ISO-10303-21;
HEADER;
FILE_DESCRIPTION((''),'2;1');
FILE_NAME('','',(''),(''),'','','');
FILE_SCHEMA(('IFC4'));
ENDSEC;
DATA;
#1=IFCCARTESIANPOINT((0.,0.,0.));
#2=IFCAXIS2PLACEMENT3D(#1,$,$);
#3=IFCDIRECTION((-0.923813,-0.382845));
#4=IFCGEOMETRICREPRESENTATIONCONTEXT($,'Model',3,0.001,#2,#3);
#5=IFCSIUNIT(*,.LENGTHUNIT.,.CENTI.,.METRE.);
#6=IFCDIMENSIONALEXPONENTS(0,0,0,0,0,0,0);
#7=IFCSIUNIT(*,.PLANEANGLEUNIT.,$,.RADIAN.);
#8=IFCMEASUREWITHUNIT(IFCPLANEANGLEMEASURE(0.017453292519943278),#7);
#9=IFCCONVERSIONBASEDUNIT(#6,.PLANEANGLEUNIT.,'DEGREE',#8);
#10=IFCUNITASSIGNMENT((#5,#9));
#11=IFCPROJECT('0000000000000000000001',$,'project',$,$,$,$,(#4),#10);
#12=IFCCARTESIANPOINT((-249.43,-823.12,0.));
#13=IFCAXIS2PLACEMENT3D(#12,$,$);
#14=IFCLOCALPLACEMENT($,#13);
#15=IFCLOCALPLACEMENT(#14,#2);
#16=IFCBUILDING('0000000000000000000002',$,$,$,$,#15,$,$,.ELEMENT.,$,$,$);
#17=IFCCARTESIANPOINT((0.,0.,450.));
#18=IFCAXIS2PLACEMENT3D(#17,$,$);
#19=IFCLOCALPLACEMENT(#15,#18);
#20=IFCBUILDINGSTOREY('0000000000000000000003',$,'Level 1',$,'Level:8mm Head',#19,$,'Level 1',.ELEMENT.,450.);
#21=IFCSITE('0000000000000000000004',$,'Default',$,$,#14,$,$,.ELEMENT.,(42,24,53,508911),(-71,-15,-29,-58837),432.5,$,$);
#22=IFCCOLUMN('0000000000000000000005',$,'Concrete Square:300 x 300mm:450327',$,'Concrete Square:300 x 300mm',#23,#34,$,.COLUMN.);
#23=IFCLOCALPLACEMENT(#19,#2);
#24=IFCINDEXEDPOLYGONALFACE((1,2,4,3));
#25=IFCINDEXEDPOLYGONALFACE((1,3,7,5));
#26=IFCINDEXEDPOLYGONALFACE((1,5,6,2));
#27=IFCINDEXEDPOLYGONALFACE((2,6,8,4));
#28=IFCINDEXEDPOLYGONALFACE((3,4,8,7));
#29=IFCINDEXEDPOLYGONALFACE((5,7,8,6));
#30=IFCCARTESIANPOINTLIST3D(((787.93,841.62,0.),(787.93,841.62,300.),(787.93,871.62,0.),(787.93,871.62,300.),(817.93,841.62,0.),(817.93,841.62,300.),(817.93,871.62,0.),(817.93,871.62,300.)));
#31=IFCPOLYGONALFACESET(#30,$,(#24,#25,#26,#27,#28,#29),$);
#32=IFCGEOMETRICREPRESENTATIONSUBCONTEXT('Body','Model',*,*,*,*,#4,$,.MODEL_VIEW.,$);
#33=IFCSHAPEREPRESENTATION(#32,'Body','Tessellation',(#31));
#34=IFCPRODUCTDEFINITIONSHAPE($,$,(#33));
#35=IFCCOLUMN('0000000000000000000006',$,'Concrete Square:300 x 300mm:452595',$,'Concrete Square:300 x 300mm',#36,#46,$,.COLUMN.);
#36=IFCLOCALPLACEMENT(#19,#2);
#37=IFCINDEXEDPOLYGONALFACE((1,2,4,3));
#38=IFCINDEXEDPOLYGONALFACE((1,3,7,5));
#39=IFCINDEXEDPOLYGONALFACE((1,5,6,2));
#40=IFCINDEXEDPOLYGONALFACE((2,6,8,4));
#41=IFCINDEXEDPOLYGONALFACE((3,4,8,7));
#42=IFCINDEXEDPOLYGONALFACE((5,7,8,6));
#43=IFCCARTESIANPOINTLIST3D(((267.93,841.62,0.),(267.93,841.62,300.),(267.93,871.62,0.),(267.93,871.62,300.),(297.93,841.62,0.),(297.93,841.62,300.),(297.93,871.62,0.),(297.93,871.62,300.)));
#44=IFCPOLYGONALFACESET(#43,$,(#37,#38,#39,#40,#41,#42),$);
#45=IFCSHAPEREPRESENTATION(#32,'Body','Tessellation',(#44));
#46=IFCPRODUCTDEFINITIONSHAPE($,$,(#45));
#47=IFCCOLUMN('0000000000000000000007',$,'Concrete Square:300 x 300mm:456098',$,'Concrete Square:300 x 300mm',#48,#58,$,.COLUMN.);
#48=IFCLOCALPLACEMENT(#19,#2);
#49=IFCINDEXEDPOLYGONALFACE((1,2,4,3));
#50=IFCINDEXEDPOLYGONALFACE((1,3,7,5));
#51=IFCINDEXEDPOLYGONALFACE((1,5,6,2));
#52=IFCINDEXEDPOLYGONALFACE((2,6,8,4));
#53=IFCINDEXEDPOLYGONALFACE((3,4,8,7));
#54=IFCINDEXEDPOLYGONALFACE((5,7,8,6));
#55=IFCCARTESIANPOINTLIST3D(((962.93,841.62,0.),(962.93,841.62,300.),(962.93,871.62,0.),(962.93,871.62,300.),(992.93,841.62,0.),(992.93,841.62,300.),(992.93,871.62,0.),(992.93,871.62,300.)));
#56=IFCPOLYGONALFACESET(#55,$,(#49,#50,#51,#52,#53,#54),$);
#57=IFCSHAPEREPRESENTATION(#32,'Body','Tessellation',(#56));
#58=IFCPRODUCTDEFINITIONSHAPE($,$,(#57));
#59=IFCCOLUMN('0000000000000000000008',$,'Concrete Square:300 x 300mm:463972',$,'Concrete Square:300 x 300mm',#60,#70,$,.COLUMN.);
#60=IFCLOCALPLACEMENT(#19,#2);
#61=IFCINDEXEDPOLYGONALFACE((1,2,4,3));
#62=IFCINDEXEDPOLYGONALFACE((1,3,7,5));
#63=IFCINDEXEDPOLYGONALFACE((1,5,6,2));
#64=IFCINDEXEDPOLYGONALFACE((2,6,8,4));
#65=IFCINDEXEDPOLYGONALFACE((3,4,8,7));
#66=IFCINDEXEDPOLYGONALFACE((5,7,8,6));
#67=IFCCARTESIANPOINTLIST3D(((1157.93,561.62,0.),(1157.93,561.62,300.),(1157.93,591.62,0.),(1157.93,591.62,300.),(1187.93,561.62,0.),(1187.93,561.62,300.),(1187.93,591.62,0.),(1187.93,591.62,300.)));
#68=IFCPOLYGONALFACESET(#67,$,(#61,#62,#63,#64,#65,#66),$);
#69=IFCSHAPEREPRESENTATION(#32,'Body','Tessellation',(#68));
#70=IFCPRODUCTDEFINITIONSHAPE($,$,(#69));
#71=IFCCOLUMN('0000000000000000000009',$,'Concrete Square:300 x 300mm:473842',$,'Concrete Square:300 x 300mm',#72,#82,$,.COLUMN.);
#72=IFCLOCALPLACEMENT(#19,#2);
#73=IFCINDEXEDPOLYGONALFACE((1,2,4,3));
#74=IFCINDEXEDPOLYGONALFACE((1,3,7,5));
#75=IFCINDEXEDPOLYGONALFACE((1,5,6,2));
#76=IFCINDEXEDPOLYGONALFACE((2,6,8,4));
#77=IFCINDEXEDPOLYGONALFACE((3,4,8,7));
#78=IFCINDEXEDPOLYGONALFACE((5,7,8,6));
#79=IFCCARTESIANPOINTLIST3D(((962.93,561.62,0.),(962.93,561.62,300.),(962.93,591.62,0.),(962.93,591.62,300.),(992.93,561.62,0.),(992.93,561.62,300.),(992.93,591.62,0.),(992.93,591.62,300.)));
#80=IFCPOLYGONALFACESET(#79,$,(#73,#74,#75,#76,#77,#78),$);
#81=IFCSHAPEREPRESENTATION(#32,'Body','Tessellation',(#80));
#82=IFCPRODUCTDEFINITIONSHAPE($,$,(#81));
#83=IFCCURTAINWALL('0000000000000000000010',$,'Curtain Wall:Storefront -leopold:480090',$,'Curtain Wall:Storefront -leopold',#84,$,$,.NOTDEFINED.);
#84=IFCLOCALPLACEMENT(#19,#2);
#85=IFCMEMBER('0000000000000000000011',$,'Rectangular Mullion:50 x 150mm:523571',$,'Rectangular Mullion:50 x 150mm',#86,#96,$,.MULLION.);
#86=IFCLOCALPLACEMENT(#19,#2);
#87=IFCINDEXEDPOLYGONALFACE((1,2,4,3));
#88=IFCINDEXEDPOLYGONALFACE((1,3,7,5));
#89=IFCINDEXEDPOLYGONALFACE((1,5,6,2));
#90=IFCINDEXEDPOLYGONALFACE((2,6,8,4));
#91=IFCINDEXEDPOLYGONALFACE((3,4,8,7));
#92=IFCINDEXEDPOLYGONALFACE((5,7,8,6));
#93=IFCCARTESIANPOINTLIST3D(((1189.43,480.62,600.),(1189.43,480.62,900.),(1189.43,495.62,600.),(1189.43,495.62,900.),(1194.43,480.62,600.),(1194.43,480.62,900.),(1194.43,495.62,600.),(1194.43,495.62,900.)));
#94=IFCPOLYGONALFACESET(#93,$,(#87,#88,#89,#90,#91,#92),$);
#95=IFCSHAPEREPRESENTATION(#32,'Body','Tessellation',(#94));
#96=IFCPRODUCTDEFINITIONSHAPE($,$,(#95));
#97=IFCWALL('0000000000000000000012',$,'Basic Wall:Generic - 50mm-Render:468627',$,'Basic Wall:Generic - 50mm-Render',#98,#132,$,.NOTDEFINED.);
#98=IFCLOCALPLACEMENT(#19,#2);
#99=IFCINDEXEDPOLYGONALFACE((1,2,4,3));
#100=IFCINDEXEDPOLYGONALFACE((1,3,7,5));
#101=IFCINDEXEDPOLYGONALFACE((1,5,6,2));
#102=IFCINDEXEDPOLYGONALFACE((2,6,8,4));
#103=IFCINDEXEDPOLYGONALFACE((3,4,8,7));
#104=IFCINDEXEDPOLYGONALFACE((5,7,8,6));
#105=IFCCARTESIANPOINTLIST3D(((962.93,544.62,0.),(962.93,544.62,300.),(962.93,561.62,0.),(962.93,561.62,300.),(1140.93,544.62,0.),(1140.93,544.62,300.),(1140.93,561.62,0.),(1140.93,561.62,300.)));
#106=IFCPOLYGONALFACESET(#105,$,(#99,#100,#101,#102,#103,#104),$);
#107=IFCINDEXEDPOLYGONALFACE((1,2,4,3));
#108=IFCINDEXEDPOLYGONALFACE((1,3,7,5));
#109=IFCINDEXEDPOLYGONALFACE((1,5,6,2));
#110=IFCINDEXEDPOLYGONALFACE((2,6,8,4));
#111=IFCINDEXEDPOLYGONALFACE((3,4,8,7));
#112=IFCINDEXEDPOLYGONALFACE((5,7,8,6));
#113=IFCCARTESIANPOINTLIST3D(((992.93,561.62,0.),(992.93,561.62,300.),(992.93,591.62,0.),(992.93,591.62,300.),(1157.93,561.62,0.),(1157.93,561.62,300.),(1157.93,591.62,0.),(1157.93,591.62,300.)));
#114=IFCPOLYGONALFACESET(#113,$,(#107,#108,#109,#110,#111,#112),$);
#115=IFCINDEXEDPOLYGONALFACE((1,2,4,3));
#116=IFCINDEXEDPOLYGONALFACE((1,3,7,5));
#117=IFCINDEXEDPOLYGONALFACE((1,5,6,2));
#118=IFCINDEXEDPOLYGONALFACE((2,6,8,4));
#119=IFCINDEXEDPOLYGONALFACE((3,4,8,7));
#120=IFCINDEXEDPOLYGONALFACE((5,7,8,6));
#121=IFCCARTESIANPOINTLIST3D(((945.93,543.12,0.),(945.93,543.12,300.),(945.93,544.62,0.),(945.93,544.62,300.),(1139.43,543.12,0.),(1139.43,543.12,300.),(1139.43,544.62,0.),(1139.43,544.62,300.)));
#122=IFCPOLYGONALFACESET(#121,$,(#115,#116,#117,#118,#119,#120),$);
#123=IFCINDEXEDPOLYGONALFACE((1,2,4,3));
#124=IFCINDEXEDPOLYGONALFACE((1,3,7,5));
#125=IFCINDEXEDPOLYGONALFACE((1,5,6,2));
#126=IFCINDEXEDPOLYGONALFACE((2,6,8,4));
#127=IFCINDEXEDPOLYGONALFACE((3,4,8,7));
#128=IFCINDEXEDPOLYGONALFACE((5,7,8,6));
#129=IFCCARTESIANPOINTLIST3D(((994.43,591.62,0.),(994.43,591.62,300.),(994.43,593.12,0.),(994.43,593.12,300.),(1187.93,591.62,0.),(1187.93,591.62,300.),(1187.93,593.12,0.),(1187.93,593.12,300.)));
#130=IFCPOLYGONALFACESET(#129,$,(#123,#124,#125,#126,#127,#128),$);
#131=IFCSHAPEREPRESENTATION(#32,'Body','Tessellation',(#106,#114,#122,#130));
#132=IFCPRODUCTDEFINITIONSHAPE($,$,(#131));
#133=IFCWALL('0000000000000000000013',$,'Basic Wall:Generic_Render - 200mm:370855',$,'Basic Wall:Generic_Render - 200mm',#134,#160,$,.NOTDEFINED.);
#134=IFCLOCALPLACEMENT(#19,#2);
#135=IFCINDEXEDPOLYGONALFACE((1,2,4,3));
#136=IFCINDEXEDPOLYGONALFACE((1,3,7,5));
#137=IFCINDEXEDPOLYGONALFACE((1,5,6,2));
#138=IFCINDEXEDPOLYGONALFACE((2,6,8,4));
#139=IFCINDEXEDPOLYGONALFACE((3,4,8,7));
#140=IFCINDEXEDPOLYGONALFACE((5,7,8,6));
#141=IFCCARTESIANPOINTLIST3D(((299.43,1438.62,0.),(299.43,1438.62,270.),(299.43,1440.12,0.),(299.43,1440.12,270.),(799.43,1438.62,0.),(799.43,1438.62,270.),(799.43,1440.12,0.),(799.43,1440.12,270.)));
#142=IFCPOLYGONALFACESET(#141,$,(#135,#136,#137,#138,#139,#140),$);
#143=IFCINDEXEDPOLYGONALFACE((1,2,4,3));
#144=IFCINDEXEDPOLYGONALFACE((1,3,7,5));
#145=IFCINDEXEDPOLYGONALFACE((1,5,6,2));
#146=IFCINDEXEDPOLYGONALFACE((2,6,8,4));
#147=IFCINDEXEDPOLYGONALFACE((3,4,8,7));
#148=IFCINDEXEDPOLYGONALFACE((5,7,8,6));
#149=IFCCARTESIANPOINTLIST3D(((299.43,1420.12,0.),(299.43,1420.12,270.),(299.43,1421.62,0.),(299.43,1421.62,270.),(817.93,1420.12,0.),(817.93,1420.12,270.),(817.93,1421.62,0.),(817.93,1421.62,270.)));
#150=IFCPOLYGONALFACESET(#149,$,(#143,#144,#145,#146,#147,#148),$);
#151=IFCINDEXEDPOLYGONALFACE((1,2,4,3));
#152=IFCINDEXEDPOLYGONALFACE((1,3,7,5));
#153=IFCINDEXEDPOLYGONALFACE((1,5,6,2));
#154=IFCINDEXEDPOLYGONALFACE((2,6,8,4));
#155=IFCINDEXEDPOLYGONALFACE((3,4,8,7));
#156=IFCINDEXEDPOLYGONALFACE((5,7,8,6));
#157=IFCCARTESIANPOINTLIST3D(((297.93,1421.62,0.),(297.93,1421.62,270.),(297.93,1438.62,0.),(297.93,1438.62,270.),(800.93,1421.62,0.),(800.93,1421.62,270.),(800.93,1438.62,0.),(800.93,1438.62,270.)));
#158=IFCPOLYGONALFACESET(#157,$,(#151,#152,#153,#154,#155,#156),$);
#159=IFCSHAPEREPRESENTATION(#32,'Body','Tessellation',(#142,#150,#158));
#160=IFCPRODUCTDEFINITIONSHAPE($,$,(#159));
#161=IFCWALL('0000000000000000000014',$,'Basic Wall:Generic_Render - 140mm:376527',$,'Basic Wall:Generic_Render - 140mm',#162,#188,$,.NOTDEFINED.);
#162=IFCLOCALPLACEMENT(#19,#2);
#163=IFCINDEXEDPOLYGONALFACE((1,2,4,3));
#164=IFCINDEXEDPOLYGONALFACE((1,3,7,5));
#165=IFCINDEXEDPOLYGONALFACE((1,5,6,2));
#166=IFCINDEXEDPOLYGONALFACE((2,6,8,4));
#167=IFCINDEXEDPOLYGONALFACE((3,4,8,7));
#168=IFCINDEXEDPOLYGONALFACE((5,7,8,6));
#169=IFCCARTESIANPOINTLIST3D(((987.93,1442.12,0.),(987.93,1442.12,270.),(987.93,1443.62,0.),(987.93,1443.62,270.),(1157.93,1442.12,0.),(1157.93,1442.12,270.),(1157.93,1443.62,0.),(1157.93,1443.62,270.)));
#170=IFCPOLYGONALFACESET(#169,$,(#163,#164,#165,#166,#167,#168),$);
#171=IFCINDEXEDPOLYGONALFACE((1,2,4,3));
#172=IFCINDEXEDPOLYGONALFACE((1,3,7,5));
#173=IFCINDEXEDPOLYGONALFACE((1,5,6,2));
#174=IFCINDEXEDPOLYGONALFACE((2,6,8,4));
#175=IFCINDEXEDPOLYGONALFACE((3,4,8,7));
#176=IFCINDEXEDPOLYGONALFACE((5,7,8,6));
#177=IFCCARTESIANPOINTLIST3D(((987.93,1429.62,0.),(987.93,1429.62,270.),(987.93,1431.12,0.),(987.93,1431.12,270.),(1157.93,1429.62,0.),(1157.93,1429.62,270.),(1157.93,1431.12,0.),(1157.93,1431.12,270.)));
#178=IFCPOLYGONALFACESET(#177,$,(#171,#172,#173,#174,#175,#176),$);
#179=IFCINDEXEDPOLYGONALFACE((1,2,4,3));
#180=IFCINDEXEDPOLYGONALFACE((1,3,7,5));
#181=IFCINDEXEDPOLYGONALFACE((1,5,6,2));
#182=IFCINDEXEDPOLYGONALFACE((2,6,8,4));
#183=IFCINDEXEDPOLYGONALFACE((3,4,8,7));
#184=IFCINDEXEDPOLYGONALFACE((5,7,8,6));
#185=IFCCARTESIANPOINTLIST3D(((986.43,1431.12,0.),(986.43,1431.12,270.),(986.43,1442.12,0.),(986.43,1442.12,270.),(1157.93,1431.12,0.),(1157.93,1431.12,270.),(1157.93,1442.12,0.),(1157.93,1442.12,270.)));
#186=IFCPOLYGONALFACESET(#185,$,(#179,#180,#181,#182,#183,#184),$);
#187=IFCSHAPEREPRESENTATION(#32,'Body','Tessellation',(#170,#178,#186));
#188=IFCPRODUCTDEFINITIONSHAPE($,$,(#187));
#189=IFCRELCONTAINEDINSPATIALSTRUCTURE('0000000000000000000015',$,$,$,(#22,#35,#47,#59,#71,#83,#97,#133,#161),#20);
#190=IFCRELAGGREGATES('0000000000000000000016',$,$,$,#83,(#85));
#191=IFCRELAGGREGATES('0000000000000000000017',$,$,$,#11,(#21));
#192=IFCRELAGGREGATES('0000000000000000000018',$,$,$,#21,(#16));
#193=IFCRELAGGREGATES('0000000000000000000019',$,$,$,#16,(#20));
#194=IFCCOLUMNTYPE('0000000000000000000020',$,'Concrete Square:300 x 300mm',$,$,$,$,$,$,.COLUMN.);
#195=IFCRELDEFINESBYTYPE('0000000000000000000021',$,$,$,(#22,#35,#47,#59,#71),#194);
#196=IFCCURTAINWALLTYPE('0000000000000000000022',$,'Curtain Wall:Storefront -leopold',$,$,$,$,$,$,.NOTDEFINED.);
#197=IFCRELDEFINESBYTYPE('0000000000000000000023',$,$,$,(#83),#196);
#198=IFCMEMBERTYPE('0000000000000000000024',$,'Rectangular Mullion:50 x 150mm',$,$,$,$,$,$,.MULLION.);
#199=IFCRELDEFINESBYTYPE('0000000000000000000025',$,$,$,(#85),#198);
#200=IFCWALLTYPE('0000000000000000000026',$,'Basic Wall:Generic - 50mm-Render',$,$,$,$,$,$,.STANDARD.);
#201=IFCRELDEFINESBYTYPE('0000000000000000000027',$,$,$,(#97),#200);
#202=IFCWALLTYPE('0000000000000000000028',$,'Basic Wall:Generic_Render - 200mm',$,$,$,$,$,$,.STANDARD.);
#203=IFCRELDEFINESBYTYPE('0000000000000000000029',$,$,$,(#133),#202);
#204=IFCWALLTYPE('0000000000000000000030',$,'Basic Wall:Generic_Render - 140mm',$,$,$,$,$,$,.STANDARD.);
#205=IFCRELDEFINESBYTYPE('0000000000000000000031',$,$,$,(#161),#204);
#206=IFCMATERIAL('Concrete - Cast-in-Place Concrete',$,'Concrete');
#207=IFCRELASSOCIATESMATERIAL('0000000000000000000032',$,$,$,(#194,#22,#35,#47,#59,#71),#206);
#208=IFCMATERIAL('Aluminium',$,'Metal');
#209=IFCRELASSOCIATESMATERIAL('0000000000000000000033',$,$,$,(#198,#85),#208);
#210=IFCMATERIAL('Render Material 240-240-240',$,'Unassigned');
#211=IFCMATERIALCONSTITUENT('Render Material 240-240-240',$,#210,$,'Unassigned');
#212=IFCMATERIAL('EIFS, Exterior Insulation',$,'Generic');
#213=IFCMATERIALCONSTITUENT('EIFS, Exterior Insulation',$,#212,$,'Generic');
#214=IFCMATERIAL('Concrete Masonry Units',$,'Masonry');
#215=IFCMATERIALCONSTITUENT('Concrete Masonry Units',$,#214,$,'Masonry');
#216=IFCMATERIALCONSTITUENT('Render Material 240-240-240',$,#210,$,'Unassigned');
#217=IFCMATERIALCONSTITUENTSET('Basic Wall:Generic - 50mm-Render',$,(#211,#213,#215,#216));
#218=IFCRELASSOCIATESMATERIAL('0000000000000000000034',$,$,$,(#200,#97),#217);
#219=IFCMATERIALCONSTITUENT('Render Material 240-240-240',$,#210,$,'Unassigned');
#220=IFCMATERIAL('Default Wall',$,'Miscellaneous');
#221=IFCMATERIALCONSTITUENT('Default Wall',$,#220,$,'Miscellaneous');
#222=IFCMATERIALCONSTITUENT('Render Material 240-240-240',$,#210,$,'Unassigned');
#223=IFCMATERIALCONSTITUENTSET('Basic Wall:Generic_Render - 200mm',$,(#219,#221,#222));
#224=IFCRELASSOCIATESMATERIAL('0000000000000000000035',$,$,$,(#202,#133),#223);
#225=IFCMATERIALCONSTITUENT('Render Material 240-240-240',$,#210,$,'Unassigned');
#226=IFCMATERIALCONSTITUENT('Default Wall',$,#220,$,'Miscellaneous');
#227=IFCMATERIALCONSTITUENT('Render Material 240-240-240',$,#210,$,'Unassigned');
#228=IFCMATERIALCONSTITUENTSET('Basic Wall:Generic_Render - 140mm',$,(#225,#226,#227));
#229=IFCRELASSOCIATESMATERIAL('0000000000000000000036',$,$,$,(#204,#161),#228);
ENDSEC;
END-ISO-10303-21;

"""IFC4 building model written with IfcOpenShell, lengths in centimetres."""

from ifc_helpers import new_model, entity, si_unit, converted_unit, direction, frame, origin, place, context, subcontext, project, spatial, indexed_curve, outline, extrude, source, transform, mapped, material, constituent, constituent_set, type_object, type_shapes, element, aggregate, save


model = new_model("IFC4")

# Units and contexts
model_context = context("Model", 3, precision=0.001, world=origin(), true_north=direction((-0.923813, -0.382845)))
body_context = subcontext(model_context, "Body", "Model", "MODEL_VIEW")
ifc_project = project(units=[si_unit("LENGTHUNIT", "METRE", prefix="CENTI"), converted_unit("PLANEANGLEUNIT", "DEGREE", entity("IfcPlaneAngleMeasure", 0.017453292519943278), si_unit("PLANEANGLEUNIT", "RADIAN"), dimensions=[0, 0, 0, 0, 0, 0, 0])], contexts=[model_context])

# Site, building, storey
site_placement = place(None, frame((-249.43, -823.12, 0.0)))
site = spatial("IfcSite", under=ifc_project, at=site_placement, Name="Default", CompositionType="ELEMENT", RefLatitude=(42, 24, 53, 508911), RefLongitude=(-71, -15, -29, -58837), RefElevation=432.5)
building_placement = place(site_placement, origin())
building = spatial("IfcBuilding", under=site, at=building_placement, CompositionType="ELEMENT")
storey_placement = place(building_placement, frame((0.0, 0.0, 450.0)))
storey = spatial("IfcBuildingStorey", under=building, at=storey_placement, Name="Level 1", ObjectType="Level:8mm Head", LongName="Level 1", CompositionType="ELEMENT", Elevation=450.0)

# Columns
ifc_material_1 = material(Name="Concrete - Cast-in-Place Concrete", Category="Concrete")
column_type = type_object("IfcColumnType", Name="Concrete Square:300 x 300mm", PredefinedType="COLUMN", material=ifc_material_1)
shared_shape_1 = source(origin(), body_context, "Body", "SweptSolid", [
    extrude(outline(indexed_curve([(-15.0, -15.0), (15.0, -15.0), (15.0, 15.0), (-15.0, 15.0), (-15.0, -15.0)], self_intersect=False)), frame((0.0, 0.0, 450.0), z_axis=(0.0, 0.0, 1.0), x_axis=(-1.0, 0.0, 0.0)), (0.0, 0.0, 1.0), 300.0),
])
type_shapes(column_type, [shared_shape_1])
for number, where, name in (
    (1, (802.93, 856.62, -450.0), "Concrete Square:300 x 300mm:450327"),
    (2, (282.93, 856.62, -450.0), "Concrete Square:300 x 300mm:452595"),
    (3, (977.93, 856.62, -450.0), "Concrete Square:300 x 300mm:456098"),
    (4, (1172.93, 576.62, -450.0), "Concrete Square:300 x 300mm:463972"),
    (5, (977.93, 576.62, -450.0), "Concrete Square:300 x 300mm:473842"),
):
    element("IfcColumn", number, at=place(storey_placement, frame(where)), inside=storey, type_object=column_type, material=ifc_material_1, Name=name, ObjectType="Concrete Square:300 x 300mm", PredefinedType="COLUMN", context=body_context, shape_type="MappedRepresentation", body=[
        mapped(shared_shape_1, transform((0.0, 0.0, 0.0), scale=1.0)),
    ])

# Curtain wall, member
curtain_wall_type = type_object("IfcCurtainWallType", Name="Curtain Wall:Storefront -leopold", PredefinedType="NOTDEFINED")
curtain_wall_placement = place(storey_placement, frame((0.0, 0.0, -450.0)))
curtain_wall = element("IfcCurtainWall", 6, at=curtain_wall_placement, inside=storey, type_object=curtain_wall_type, Name="Curtain Wall:Storefront -leopold:480090", ObjectType="Curtain Wall:Storefront -leopold", PredefinedType="NOTDEFINED")
ifc_material_2 = material(Name="Aluminium", Category="Metal")
member_type = type_object("IfcMemberType", Name="Rectangular Mullion:50 x 150mm", PredefinedType="MULLION", material=ifc_material_2)
shared_shape_2 = source(origin(), body_context, "Body", "SweptSolid", [
    extrude(outline(indexed_curve([(-2.5, -7.5), (2.5, -7.5), (2.5, 7.5), (-2.5, 7.5), (-2.5, -7.5)], self_intersect=False)), frame((-2.5, 0.0, -300.0), z_axis=(0.0, 0.0, 1.0), x_axis=(-1.0, 0.0, 0.0)), (0.0, 0.0, 1.0), 300.0),
])
type_shapes(member_type, [shared_shape_2])
member_placement = place(curtain_wall_placement, frame((1189.43, 488.12, 1350.0), z_axis=(0.0, 0.0, 1.0), x_axis=(-1.0, 0.0, 0.0)))
member = element("IfcMember", 7, at=member_placement, type_object=member_type, material=ifc_material_2, Name="Rectangular Mullion:50 x 150mm:523571", ObjectType="Rectangular Mullion:50 x 150mm", PredefinedType="MULLION", context=body_context, shape_type="MappedRepresentation", body=[
    mapped(shared_shape_2, transform((0.0, 0.0, 0.0), scale=1.0)),
])
aggregate(curtain_wall, [member])

# Walls
ifc_material_3 = material(Name="Render Material 240-240-240", Category="Unassigned")
ifc_constituent_1 = constituent(ifc_material_3, Name="Render Material 240-240-240", Category="Unassigned")
ifc_material_4 = material(Name="EIFS, Exterior Insulation", Category="Generic")
ifc_constituent_2 = constituent(ifc_material_4, Name="EIFS, Exterior Insulation", Category="Generic")
ifc_material_5 = material(Name="Concrete Masonry Units", Category="Masonry")
ifc_constituent_3 = constituent(ifc_material_5, Name="Concrete Masonry Units", Category="Masonry")
ifc_constituent_4 = constituent(ifc_material_3, Name="Render Material 240-240-240", Category="Unassigned")
ifc_constituent_set_1 = constituent_set(constituents=[ifc_constituent_1, ifc_constituent_2, ifc_constituent_3, ifc_constituent_4], Name="Basic Wall:Generic - 50mm-Render")
wall_type_1 = type_object("IfcWallType", Name="Basic Wall:Generic - 50mm-Render", PredefinedType="STANDARD", material=ifc_constituent_set_1)
wall_1_placement = place(storey_placement, frame((1139.43, 568.12, 0.0), z_axis=(0.0, 0.0, 1.0), x_axis=(-1.0, 0.0, 0.0)))
element("IfcWall", 8, at=wall_1_placement, inside=storey, type_object=wall_type_1, material=ifc_constituent_set_1, Name="Basic Wall:Generic - 50mm-Render:468627", ObjectType="Basic Wall:Generic - 50mm-Render", PredefinedType="NOTDEFINED", context=body_context, shape_type="SweptSolid", body=[
    extrude(outline(indexed_curve([(-89.0, -8.5), (89.0, -8.5), (89.0, 8.5), (-89.0, 8.5), (-89.0, -8.5)], self_intersect=False)), frame((87.5, 15.0, 0.0)), (0.0, 0.0, 1.0), 300.0),
    extrude(outline(indexed_curve([(-82.5, -15.0), (82.5, -15.0), (82.5, 15.0), (-82.5, 15.0), (-82.5, -15.0)], self_intersect=False)), frame((64.0, -8.5, 0.0)), (0.0, 0.0, 1.0), 300.0),
    extrude(outline(indexed_curve([(-0.75, -96.75), (0.75, -96.75), (0.75, 96.75), (-0.75, 96.75), (-0.75, -96.75)], self_intersect=False)), frame((96.75, 24.25, 0.0), z_axis=(0.0, 0.0, 1.0), x_axis=(0.0, -1.0, 0.0)), (0.0, 0.0, 1.0), 300.0),
    extrude(outline(indexed_curve([(-0.75, -96.75), (0.75, -96.75), (0.75, 96.75), (-0.75, 96.75), (-0.75, -96.75)], self_intersect=False)), frame((48.25, -24.25, 0.0), z_axis=(0.0, 0.0, 1.0), x_axis=(0.0, 1.0, 0.0)), (0.0, 0.0, 1.0), 300.0),
])
ifc_constituent_5 = constituent(ifc_material_3, Name="Render Material 240-240-240", Category="Unassigned")
ifc_material_6 = material(Name="Default Wall", Category="Miscellaneous")
ifc_constituent_6 = constituent(ifc_material_6, Name="Default Wall", Category="Miscellaneous")
ifc_constituent_7 = constituent(ifc_material_3, Name="Render Material 240-240-240", Category="Unassigned")
ifc_constituent_set_2 = constituent_set(constituents=[ifc_constituent_5, ifc_constituent_6, ifc_constituent_7], Name="Basic Wall:Generic_Render - 200mm")
wall_type_2 = type_object("IfcWallType", Name="Basic Wall:Generic_Render - 200mm", PredefinedType="STANDARD", material=ifc_constituent_set_2)
wall_2_placement = place(storey_placement, frame((799.43, 1430.12, 0.0), z_axis=(0.0, 0.0, 1.0), x_axis=(-1.0, 0.0, 0.0)))
element("IfcWall", 9, at=wall_2_placement, inside=storey, type_object=wall_type_2, material=ifc_constituent_set_2, Name="Basic Wall:Generic_Render - 200mm:370855", ObjectType="Basic Wall:Generic_Render - 200mm", PredefinedType="NOTDEFINED", context=body_context, shape_type="SweptSolid", body=[
    extrude(outline(indexed_curve([(-0.75, -250.0), (0.75, -250.0), (0.75, 250.0), (-0.75, 250.0), (-0.75, -250.0)], self_intersect=False)), frame((250.0, -9.25, 0.0), z_axis=(0.0, 0.0, 1.0), x_axis=(0.0, 1.0, 0.0)), (0.0, 0.0, 1.0), 270.0),
    extrude(outline(indexed_curve([(-0.75, -259.25), (0.75, -259.25), (0.75, 259.25), (-0.75, 259.25), (-0.75, -259.25)], self_intersect=False)), frame((240.75, 9.25, 0.0), z_axis=(0.0, 0.0, 1.0), x_axis=(0.0, -1.0, 0.0)), (0.0, 0.0, 1.0), 270.0),
    extrude(outline(indexed_curve([(-251.5, -8.5), (251.5, -8.5), (251.5, 8.5), (-251.5, 8.5), (-251.5, -8.5)], self_intersect=False)), frame((250.0, 0.0, 0.0)), (0.0, 0.0, 1.0), 270.0),
])
ifc_constituent_8 = constituent(ifc_material_3, Name="Render Material 240-240-240", Category="Unassigned")
ifc_constituent_9 = constituent(ifc_material_6, Name="Default Wall", Category="Miscellaneous")
ifc_constituent_10 = constituent(ifc_material_3, Name="Render Material 240-240-240", Category="Unassigned")
ifc_constituent_set_3 = constituent_set(constituents=[ifc_constituent_8, ifc_constituent_9, ifc_constituent_10], Name="Basic Wall:Generic_Render - 140mm")
wall_type_3 = type_object("IfcWallType", Name="Basic Wall:Generic_Render - 140mm", PredefinedType="STANDARD", material=ifc_constituent_set_3)
wall_3_placement = place(storey_placement, frame((1157.93, 1436.62, 0.0), z_axis=(0.0, 0.0, 1.0), x_axis=(-1.0, 0.0, 0.0)))
element("IfcWall", 10, at=wall_3_placement, inside=storey, type_object=wall_type_3, material=ifc_constituent_set_3, Name="Basic Wall:Generic_Render - 140mm:376527", ObjectType="Basic Wall:Generic_Render - 140mm", PredefinedType="NOTDEFINED", context=body_context, shape_type="SweptSolid", body=[
    extrude(outline(indexed_curve([(-0.75, -85.0), (0.75, -85.0), (0.75, 85.0), (-0.75, 85.0), (-0.75, -85.0)], self_intersect=False)), frame((85.0, -6.25, 0.0), z_axis=(0.0, 0.0, 1.0), x_axis=(0.0, 1.0, 0.0)), (0.0, 0.0, 1.0), 270.0),
    extrude(outline(indexed_curve([(-0.75, -85.0), (0.75, -85.0), (0.75, 85.0), (-0.75, 85.0), (-0.75, -85.0)], self_intersect=False)), frame((85.0, 6.25, 0.0), z_axis=(0.0, 0.0, 1.0), x_axis=(0.0, -1.0, 0.0)), (0.0, 0.0, 1.0), 270.0),
    extrude(outline(indexed_curve([(-85.75, -5.5), (85.75, -5.5), (85.75, 5.5), (-85.75, 5.5), (-85.75, -5.5)], self_intersect=False)), frame((85.75, 0.0, 0.0)), (0.0, 0.0, 1.0), 270.0),
])

save(model, "model.ifc")
